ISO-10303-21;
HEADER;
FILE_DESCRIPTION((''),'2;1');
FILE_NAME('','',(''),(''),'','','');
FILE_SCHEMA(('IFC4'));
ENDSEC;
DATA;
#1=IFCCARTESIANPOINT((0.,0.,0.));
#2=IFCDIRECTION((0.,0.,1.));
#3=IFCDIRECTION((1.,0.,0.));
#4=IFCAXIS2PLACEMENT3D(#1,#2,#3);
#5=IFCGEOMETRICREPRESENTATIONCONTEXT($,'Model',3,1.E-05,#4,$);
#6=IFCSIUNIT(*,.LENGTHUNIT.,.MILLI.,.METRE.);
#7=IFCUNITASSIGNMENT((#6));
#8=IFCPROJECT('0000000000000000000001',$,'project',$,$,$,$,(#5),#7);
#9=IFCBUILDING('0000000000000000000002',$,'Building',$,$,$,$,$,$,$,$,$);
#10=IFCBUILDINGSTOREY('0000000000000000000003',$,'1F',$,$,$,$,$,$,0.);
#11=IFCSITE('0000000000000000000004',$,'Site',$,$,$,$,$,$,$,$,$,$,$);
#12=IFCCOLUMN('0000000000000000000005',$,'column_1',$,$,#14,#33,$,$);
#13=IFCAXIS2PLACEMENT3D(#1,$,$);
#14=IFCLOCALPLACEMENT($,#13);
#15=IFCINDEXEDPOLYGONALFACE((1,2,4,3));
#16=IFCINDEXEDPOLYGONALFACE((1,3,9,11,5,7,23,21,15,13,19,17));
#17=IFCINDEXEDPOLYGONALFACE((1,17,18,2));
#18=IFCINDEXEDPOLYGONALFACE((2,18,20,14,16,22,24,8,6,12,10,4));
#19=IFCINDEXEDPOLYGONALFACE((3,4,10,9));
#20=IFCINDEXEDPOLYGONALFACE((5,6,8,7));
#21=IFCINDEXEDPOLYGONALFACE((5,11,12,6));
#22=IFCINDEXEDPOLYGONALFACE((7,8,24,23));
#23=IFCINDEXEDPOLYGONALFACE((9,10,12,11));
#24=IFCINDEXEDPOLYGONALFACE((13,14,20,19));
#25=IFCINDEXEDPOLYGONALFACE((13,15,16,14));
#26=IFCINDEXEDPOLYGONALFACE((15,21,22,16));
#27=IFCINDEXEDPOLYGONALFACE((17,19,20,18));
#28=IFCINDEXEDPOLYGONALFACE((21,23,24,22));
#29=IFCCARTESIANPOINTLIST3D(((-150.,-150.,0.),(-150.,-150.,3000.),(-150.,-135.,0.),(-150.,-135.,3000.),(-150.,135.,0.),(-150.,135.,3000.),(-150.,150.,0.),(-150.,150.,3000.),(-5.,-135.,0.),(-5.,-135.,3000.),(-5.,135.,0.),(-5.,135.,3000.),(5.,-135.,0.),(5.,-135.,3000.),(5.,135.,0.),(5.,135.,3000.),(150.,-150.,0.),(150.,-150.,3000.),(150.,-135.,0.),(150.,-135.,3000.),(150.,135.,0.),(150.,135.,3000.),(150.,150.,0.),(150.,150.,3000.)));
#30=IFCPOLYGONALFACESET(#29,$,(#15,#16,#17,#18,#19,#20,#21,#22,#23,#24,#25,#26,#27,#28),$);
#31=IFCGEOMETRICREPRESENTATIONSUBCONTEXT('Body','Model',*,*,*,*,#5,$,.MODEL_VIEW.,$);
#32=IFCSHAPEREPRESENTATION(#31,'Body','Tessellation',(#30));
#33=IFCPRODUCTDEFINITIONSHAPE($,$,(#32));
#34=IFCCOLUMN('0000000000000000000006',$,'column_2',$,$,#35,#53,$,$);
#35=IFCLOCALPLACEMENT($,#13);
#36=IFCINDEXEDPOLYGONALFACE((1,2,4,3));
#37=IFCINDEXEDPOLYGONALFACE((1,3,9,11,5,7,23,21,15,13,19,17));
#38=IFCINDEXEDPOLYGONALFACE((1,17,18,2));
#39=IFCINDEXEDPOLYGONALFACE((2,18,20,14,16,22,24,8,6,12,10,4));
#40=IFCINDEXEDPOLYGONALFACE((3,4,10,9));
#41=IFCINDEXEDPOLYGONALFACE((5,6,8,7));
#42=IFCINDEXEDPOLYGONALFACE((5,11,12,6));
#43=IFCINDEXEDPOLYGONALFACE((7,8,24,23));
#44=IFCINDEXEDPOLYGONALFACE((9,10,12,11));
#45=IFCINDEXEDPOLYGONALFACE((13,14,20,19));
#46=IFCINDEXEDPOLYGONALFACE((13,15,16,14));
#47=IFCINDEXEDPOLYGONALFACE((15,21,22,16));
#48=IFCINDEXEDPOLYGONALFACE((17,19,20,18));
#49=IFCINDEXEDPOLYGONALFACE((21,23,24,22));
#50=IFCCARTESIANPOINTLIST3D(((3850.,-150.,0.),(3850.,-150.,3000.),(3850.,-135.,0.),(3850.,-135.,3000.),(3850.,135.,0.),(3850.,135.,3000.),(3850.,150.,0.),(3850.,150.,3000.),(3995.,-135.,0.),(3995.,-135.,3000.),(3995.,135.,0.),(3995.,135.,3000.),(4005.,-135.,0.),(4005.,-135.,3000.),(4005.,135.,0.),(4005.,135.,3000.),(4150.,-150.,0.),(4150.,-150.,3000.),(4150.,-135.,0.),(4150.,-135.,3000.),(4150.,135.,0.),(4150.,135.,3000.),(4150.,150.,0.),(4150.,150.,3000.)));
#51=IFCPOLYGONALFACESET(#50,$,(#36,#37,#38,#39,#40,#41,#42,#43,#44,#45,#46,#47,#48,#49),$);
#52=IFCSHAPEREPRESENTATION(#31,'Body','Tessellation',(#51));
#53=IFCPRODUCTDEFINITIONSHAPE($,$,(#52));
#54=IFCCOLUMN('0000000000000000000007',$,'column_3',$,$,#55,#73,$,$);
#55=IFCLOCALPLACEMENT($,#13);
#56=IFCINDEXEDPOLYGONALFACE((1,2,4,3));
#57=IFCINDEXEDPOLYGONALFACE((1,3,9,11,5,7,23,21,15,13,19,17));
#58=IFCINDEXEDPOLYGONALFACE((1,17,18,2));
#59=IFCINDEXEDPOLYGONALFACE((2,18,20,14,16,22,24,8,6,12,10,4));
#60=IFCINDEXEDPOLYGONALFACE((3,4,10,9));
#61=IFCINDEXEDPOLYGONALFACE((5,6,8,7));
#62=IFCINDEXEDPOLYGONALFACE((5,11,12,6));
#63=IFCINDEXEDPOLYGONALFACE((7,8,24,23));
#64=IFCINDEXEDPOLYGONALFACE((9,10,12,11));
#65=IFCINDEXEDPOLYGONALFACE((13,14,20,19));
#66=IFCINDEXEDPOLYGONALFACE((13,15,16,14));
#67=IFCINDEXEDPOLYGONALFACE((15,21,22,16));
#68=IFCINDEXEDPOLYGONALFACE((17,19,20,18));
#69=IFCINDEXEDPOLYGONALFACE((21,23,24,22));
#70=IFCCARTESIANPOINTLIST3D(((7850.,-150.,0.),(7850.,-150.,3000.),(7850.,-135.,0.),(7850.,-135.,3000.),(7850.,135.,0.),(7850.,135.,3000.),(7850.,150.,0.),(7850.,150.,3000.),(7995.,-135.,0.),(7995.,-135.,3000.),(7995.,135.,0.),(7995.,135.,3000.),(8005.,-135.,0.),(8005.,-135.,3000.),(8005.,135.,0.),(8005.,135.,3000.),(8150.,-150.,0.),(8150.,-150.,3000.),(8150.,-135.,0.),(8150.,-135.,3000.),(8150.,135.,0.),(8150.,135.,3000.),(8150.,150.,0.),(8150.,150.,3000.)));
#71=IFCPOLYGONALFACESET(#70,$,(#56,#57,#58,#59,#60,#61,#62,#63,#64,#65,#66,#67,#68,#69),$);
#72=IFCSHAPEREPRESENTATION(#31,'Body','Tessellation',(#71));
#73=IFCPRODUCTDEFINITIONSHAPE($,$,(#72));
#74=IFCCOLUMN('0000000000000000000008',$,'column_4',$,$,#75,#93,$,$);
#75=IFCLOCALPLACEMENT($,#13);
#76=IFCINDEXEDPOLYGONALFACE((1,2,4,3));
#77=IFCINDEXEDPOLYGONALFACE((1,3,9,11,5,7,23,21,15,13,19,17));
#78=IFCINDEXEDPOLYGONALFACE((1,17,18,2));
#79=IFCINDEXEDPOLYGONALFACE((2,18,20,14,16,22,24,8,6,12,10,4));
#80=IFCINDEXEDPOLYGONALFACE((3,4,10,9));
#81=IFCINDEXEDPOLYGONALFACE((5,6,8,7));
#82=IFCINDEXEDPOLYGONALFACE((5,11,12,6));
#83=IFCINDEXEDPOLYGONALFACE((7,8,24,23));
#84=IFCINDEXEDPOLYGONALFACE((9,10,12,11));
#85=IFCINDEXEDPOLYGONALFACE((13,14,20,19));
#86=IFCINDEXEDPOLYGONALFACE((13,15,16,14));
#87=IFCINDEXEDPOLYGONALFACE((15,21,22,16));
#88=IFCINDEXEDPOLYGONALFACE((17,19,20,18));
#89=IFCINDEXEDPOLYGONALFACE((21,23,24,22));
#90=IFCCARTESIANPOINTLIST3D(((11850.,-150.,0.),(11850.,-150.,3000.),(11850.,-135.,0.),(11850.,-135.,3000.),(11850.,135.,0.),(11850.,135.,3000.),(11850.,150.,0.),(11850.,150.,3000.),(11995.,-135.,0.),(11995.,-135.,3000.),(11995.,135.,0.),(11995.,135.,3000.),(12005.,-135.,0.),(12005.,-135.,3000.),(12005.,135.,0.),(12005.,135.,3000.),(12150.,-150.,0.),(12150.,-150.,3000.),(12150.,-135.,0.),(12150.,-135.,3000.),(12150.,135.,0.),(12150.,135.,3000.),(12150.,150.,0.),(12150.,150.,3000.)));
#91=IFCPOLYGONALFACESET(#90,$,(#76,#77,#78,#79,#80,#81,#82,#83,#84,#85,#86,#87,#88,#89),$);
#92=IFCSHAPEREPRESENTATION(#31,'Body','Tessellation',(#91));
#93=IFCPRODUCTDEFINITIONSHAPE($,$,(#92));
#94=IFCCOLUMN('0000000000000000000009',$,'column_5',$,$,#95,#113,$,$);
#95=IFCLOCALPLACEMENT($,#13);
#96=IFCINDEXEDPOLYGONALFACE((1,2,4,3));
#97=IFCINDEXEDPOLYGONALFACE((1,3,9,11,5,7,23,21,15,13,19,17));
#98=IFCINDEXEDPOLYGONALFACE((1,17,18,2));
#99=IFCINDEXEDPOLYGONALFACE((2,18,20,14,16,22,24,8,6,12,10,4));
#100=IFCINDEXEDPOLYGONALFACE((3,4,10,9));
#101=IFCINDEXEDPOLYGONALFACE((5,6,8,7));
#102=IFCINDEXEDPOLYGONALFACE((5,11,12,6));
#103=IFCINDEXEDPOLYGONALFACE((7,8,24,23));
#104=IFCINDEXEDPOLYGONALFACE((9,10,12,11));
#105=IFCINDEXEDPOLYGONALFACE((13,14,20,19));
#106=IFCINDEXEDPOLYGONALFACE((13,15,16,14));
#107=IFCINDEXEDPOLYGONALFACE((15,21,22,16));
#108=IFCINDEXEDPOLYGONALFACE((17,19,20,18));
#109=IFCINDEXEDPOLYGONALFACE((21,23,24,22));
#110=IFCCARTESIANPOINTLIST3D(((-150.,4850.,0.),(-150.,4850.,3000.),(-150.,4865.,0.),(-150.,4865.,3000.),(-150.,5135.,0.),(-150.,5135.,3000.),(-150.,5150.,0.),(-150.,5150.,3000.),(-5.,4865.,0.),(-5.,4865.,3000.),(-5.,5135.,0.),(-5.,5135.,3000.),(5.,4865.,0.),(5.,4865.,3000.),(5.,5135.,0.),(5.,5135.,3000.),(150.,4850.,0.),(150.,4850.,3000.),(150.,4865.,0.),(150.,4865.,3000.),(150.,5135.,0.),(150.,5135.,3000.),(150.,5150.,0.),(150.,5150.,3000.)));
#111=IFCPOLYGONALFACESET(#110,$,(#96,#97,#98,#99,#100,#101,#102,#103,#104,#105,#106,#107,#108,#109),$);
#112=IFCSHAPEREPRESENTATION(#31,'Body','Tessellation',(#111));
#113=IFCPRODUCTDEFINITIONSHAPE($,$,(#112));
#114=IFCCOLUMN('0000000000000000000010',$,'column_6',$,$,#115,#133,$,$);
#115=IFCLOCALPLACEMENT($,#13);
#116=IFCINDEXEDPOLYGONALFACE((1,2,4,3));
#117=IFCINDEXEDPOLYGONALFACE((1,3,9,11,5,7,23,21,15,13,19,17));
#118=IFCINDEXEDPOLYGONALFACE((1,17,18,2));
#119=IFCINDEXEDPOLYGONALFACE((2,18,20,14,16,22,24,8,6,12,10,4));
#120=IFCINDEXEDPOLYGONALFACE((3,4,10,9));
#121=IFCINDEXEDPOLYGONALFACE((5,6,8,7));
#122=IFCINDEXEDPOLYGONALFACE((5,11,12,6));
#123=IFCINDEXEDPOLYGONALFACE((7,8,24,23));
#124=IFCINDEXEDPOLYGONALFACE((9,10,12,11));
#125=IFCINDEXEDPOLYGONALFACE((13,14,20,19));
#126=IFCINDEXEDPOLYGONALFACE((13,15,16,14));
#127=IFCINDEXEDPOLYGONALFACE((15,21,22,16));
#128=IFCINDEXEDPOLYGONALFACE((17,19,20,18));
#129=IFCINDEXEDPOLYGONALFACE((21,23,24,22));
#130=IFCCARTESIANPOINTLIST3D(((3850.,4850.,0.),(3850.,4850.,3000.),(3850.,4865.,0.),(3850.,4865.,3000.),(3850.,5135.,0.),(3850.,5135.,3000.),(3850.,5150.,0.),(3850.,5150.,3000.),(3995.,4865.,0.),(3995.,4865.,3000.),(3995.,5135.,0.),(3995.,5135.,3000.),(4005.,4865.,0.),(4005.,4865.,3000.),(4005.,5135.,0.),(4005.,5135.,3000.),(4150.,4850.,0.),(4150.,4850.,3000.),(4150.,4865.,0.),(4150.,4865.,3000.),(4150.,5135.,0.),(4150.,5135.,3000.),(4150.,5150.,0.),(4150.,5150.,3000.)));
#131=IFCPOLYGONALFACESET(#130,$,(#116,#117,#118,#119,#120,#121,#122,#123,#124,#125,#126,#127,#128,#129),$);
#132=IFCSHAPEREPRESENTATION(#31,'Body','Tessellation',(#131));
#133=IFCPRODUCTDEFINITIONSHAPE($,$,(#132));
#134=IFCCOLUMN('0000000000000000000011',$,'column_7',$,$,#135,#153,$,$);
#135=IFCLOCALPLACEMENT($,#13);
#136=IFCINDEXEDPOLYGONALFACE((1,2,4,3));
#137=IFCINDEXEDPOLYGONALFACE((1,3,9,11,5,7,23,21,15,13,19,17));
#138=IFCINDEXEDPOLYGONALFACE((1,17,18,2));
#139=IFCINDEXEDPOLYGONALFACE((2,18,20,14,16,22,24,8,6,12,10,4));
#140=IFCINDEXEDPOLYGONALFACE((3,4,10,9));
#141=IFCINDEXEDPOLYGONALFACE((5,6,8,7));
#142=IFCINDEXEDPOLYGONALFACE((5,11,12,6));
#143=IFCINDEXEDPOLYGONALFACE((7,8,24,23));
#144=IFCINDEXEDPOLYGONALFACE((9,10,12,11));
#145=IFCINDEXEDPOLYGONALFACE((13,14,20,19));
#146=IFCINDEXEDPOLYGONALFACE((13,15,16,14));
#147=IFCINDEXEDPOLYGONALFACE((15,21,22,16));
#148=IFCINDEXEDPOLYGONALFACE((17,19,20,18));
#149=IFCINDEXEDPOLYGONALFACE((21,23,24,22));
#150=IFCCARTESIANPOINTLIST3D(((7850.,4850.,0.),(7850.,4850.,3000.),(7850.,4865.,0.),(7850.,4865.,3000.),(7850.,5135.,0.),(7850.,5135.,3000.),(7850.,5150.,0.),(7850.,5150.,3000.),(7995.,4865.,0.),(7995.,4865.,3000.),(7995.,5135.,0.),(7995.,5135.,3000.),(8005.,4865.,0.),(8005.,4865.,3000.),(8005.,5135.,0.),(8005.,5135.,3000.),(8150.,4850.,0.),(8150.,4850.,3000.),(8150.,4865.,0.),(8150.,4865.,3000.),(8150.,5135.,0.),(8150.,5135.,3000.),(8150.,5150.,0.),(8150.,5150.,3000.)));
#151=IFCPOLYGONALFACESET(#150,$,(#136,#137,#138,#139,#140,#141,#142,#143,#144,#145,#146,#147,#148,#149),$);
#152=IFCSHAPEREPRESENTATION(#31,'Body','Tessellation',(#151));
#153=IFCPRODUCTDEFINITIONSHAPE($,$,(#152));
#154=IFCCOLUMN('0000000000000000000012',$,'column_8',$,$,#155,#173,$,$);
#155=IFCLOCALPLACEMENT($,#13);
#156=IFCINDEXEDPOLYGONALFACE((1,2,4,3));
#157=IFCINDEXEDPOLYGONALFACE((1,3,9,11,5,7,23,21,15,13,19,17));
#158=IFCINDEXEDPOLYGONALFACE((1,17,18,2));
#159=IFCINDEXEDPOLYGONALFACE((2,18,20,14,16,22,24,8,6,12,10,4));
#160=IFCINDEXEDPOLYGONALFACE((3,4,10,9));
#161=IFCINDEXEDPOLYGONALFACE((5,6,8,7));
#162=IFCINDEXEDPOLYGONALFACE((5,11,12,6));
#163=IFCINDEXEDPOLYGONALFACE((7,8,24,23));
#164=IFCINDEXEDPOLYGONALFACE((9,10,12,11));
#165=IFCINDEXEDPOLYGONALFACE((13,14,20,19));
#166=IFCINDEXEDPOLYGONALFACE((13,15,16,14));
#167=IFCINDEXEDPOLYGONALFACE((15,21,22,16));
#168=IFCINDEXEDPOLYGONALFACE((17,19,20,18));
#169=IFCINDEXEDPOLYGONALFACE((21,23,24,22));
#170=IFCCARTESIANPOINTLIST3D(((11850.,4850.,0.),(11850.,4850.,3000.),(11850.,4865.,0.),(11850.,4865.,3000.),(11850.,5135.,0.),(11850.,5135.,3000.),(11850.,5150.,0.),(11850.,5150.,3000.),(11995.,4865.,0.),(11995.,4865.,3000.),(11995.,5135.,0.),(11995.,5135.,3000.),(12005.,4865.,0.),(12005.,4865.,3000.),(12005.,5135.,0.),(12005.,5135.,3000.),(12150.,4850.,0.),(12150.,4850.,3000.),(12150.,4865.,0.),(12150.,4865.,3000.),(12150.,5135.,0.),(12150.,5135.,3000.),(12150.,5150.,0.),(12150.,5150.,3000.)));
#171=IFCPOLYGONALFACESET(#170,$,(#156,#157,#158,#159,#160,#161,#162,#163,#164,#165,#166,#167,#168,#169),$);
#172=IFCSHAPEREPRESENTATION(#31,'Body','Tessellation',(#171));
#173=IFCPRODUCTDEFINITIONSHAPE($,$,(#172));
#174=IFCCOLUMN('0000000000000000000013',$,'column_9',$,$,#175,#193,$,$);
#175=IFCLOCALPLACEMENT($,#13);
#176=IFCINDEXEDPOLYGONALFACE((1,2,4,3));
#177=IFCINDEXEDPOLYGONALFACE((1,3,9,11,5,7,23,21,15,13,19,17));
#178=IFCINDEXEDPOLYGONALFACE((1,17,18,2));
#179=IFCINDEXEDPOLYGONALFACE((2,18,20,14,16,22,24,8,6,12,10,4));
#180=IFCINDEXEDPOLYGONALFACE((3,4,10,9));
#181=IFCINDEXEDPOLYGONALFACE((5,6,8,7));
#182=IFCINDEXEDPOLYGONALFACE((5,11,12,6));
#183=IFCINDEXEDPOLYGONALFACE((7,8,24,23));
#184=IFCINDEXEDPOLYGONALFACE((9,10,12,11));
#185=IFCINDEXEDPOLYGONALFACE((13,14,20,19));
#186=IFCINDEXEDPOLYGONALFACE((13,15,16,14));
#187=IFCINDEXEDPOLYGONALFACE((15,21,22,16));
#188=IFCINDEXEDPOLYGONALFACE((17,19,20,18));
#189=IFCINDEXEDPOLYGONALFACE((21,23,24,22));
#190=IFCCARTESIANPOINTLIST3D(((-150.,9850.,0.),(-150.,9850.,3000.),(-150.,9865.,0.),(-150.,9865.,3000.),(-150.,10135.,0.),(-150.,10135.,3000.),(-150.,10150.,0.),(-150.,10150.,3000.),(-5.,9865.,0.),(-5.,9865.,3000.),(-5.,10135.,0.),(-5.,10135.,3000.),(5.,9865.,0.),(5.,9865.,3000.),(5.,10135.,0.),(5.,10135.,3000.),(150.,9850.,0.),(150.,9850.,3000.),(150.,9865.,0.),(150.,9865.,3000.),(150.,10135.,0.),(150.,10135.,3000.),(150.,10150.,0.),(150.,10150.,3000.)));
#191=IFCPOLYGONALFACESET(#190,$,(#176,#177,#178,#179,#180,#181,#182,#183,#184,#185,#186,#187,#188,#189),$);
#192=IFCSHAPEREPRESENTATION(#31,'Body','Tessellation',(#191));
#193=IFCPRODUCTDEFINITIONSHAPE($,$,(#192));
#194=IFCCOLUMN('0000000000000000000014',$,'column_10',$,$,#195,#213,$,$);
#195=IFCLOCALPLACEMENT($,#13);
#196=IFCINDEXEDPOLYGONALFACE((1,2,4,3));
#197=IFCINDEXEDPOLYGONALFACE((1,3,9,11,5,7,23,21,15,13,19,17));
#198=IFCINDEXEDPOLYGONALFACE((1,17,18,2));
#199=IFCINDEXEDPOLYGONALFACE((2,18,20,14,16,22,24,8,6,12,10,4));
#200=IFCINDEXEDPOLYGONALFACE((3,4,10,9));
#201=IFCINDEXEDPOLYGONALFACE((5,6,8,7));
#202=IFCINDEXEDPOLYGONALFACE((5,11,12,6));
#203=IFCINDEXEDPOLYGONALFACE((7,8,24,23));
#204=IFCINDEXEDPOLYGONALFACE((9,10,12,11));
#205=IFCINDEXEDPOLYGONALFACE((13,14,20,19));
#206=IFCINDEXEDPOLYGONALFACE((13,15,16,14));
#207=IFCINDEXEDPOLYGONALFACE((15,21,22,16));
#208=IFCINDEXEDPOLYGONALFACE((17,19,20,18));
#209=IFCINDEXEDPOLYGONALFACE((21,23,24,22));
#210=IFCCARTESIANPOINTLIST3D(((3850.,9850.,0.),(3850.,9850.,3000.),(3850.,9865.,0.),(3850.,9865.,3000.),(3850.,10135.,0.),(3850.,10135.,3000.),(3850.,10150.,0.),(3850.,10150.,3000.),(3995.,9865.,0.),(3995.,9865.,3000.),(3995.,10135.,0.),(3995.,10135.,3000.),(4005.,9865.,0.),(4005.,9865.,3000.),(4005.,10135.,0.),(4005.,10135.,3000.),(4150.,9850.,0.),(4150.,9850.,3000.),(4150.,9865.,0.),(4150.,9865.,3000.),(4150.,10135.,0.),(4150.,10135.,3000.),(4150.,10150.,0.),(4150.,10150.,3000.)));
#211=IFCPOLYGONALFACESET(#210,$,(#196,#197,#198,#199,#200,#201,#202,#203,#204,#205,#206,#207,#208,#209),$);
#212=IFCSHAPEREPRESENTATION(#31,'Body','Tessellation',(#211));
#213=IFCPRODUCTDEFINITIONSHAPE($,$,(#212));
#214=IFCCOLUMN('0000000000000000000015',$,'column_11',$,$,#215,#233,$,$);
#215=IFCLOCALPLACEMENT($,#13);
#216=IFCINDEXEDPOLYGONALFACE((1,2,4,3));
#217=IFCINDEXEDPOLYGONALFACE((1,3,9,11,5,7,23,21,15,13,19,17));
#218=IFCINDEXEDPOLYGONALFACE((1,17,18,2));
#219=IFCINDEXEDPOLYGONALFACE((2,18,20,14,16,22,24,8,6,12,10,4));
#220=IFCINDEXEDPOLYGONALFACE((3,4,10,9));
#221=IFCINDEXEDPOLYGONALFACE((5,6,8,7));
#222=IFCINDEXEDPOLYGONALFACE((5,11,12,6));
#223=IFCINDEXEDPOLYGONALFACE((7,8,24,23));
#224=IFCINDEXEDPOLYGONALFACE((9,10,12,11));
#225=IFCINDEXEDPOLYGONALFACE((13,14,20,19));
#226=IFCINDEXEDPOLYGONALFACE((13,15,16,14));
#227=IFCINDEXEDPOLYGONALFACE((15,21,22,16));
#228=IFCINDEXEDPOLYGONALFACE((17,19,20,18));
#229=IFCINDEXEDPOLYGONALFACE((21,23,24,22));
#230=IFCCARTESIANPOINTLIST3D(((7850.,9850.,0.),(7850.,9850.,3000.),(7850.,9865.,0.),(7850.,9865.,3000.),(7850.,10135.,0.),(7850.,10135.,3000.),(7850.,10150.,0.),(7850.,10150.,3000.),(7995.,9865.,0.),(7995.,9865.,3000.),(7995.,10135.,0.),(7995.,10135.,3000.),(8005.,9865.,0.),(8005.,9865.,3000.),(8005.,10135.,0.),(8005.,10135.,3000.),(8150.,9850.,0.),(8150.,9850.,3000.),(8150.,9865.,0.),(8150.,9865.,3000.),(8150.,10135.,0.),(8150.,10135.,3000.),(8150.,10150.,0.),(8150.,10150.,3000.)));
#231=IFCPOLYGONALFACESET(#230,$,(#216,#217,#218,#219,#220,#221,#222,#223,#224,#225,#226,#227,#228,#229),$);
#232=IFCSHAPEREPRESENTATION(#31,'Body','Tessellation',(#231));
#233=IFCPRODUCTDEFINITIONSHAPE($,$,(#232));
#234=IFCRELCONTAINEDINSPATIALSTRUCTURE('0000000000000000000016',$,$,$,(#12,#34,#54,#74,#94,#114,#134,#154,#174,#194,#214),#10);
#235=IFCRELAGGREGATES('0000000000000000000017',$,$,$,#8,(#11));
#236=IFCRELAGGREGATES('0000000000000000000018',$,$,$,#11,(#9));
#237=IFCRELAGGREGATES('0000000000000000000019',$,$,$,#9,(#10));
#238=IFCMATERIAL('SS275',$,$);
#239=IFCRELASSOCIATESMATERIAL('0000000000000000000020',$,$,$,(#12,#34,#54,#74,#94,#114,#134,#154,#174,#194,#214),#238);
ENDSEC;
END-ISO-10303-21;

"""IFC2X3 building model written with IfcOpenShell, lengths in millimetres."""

from ifc_helpers import new_model, si_unit, frame, origin, origin_with_axes, origin_2d_with_axis, place, context, subcontext, project, spatial, i_section, extrude, material, element, save


model = new_model("IFC2X3")

# Units and contexts
model_context = context("Model", 3, precision=1e-05, world=origin_with_axes())
body_context = subcontext(model_context, "Body", "Model", "MODEL_VIEW")
ifc_project = project(units=[si_unit("LENGTHUNIT", "METRE", prefix="MILLI")], contexts=[model_context])

# Site, building, storey
site = spatial("IfcSite", under=ifc_project, Name="Site")
building = spatial("IfcBuilding", under=site, Name="Building")
storey = spatial("IfcBuildingStorey", under=building, Name="1F", Elevation=0.0)

# Columns
ifc_material = material(Name="SS275")
for number, where, z_axis, x_axis, name in (
    (1, (0.0, 0.0, 0.0), (0.0, 0.0, 1.0), (1.0, 0.0, 0.0), "column_1"),
    (2, (4000.0, 0.0, 0.0), (0.0, 0.0, 1.0), (1.0, 0.0, 0.0), "column_2"),
    (3, (8000.0, 0.0, 0.0), (0.0, 0.0, 1.0), (1.0, 0.0, 0.0), "column_3"),
    (4, (12000.0, 0.0, 0.0), (0.0, 0.0, 1.0), (1.0, 0.0, 0.0), "column_4"),
    (5, (0.0, 5000.0, 0.0), (0.0, 0.0, 1.0), (1.0, 0.0, 0.0), "column_5"),
    (6, (4000.0, 5000.0, 0.0), (0.0, 0.0, 1.0), (1.0, 0.0, 0.0), "column_6"),
    (7, (8000.0, 5000.0, 0.0), (0.0, 0.0, 1.0), (1.0, 0.0, 0.0), "column_7"),
    (8, (12000.0, 5000.0, 0.0), (0.0, 0.0, 1.0), (1.0, 0.0, 0.0), "column_8"),
    (9, (0.0, 10000.0, 0.0), (0.0, 0.0, 1.0), (1.0, 0.0, 0.0), "column_9"),
    (10, (4000.0, 10000.0, 0.0), (0.0, 0.0, 1.0), (1.0, 0.0, 0.0), "column_10"),
    (11, (8000.0, 10000.0, 0.0), (0.0, 0.0, 1.0), (1.0, 0.0, 0.0), "column_11"),
):
    element("IfcColumn", number, at=place(None, frame(where, z_axis=z_axis, x_axis=x_axis)), inside=storey, material=ifc_material, Name=name, context=body_context, shape_type="SweptSolid", body=[
        extrude(i_section(OverallWidth=300.0, OverallDepth=300.0, WebThickness=10.0, FlangeThickness=15.0, at=origin_2d_with_axis()), origin(), (0.0, 0.0, 1.0), 3000.0),
    ])

save(model, "model.ifc")
